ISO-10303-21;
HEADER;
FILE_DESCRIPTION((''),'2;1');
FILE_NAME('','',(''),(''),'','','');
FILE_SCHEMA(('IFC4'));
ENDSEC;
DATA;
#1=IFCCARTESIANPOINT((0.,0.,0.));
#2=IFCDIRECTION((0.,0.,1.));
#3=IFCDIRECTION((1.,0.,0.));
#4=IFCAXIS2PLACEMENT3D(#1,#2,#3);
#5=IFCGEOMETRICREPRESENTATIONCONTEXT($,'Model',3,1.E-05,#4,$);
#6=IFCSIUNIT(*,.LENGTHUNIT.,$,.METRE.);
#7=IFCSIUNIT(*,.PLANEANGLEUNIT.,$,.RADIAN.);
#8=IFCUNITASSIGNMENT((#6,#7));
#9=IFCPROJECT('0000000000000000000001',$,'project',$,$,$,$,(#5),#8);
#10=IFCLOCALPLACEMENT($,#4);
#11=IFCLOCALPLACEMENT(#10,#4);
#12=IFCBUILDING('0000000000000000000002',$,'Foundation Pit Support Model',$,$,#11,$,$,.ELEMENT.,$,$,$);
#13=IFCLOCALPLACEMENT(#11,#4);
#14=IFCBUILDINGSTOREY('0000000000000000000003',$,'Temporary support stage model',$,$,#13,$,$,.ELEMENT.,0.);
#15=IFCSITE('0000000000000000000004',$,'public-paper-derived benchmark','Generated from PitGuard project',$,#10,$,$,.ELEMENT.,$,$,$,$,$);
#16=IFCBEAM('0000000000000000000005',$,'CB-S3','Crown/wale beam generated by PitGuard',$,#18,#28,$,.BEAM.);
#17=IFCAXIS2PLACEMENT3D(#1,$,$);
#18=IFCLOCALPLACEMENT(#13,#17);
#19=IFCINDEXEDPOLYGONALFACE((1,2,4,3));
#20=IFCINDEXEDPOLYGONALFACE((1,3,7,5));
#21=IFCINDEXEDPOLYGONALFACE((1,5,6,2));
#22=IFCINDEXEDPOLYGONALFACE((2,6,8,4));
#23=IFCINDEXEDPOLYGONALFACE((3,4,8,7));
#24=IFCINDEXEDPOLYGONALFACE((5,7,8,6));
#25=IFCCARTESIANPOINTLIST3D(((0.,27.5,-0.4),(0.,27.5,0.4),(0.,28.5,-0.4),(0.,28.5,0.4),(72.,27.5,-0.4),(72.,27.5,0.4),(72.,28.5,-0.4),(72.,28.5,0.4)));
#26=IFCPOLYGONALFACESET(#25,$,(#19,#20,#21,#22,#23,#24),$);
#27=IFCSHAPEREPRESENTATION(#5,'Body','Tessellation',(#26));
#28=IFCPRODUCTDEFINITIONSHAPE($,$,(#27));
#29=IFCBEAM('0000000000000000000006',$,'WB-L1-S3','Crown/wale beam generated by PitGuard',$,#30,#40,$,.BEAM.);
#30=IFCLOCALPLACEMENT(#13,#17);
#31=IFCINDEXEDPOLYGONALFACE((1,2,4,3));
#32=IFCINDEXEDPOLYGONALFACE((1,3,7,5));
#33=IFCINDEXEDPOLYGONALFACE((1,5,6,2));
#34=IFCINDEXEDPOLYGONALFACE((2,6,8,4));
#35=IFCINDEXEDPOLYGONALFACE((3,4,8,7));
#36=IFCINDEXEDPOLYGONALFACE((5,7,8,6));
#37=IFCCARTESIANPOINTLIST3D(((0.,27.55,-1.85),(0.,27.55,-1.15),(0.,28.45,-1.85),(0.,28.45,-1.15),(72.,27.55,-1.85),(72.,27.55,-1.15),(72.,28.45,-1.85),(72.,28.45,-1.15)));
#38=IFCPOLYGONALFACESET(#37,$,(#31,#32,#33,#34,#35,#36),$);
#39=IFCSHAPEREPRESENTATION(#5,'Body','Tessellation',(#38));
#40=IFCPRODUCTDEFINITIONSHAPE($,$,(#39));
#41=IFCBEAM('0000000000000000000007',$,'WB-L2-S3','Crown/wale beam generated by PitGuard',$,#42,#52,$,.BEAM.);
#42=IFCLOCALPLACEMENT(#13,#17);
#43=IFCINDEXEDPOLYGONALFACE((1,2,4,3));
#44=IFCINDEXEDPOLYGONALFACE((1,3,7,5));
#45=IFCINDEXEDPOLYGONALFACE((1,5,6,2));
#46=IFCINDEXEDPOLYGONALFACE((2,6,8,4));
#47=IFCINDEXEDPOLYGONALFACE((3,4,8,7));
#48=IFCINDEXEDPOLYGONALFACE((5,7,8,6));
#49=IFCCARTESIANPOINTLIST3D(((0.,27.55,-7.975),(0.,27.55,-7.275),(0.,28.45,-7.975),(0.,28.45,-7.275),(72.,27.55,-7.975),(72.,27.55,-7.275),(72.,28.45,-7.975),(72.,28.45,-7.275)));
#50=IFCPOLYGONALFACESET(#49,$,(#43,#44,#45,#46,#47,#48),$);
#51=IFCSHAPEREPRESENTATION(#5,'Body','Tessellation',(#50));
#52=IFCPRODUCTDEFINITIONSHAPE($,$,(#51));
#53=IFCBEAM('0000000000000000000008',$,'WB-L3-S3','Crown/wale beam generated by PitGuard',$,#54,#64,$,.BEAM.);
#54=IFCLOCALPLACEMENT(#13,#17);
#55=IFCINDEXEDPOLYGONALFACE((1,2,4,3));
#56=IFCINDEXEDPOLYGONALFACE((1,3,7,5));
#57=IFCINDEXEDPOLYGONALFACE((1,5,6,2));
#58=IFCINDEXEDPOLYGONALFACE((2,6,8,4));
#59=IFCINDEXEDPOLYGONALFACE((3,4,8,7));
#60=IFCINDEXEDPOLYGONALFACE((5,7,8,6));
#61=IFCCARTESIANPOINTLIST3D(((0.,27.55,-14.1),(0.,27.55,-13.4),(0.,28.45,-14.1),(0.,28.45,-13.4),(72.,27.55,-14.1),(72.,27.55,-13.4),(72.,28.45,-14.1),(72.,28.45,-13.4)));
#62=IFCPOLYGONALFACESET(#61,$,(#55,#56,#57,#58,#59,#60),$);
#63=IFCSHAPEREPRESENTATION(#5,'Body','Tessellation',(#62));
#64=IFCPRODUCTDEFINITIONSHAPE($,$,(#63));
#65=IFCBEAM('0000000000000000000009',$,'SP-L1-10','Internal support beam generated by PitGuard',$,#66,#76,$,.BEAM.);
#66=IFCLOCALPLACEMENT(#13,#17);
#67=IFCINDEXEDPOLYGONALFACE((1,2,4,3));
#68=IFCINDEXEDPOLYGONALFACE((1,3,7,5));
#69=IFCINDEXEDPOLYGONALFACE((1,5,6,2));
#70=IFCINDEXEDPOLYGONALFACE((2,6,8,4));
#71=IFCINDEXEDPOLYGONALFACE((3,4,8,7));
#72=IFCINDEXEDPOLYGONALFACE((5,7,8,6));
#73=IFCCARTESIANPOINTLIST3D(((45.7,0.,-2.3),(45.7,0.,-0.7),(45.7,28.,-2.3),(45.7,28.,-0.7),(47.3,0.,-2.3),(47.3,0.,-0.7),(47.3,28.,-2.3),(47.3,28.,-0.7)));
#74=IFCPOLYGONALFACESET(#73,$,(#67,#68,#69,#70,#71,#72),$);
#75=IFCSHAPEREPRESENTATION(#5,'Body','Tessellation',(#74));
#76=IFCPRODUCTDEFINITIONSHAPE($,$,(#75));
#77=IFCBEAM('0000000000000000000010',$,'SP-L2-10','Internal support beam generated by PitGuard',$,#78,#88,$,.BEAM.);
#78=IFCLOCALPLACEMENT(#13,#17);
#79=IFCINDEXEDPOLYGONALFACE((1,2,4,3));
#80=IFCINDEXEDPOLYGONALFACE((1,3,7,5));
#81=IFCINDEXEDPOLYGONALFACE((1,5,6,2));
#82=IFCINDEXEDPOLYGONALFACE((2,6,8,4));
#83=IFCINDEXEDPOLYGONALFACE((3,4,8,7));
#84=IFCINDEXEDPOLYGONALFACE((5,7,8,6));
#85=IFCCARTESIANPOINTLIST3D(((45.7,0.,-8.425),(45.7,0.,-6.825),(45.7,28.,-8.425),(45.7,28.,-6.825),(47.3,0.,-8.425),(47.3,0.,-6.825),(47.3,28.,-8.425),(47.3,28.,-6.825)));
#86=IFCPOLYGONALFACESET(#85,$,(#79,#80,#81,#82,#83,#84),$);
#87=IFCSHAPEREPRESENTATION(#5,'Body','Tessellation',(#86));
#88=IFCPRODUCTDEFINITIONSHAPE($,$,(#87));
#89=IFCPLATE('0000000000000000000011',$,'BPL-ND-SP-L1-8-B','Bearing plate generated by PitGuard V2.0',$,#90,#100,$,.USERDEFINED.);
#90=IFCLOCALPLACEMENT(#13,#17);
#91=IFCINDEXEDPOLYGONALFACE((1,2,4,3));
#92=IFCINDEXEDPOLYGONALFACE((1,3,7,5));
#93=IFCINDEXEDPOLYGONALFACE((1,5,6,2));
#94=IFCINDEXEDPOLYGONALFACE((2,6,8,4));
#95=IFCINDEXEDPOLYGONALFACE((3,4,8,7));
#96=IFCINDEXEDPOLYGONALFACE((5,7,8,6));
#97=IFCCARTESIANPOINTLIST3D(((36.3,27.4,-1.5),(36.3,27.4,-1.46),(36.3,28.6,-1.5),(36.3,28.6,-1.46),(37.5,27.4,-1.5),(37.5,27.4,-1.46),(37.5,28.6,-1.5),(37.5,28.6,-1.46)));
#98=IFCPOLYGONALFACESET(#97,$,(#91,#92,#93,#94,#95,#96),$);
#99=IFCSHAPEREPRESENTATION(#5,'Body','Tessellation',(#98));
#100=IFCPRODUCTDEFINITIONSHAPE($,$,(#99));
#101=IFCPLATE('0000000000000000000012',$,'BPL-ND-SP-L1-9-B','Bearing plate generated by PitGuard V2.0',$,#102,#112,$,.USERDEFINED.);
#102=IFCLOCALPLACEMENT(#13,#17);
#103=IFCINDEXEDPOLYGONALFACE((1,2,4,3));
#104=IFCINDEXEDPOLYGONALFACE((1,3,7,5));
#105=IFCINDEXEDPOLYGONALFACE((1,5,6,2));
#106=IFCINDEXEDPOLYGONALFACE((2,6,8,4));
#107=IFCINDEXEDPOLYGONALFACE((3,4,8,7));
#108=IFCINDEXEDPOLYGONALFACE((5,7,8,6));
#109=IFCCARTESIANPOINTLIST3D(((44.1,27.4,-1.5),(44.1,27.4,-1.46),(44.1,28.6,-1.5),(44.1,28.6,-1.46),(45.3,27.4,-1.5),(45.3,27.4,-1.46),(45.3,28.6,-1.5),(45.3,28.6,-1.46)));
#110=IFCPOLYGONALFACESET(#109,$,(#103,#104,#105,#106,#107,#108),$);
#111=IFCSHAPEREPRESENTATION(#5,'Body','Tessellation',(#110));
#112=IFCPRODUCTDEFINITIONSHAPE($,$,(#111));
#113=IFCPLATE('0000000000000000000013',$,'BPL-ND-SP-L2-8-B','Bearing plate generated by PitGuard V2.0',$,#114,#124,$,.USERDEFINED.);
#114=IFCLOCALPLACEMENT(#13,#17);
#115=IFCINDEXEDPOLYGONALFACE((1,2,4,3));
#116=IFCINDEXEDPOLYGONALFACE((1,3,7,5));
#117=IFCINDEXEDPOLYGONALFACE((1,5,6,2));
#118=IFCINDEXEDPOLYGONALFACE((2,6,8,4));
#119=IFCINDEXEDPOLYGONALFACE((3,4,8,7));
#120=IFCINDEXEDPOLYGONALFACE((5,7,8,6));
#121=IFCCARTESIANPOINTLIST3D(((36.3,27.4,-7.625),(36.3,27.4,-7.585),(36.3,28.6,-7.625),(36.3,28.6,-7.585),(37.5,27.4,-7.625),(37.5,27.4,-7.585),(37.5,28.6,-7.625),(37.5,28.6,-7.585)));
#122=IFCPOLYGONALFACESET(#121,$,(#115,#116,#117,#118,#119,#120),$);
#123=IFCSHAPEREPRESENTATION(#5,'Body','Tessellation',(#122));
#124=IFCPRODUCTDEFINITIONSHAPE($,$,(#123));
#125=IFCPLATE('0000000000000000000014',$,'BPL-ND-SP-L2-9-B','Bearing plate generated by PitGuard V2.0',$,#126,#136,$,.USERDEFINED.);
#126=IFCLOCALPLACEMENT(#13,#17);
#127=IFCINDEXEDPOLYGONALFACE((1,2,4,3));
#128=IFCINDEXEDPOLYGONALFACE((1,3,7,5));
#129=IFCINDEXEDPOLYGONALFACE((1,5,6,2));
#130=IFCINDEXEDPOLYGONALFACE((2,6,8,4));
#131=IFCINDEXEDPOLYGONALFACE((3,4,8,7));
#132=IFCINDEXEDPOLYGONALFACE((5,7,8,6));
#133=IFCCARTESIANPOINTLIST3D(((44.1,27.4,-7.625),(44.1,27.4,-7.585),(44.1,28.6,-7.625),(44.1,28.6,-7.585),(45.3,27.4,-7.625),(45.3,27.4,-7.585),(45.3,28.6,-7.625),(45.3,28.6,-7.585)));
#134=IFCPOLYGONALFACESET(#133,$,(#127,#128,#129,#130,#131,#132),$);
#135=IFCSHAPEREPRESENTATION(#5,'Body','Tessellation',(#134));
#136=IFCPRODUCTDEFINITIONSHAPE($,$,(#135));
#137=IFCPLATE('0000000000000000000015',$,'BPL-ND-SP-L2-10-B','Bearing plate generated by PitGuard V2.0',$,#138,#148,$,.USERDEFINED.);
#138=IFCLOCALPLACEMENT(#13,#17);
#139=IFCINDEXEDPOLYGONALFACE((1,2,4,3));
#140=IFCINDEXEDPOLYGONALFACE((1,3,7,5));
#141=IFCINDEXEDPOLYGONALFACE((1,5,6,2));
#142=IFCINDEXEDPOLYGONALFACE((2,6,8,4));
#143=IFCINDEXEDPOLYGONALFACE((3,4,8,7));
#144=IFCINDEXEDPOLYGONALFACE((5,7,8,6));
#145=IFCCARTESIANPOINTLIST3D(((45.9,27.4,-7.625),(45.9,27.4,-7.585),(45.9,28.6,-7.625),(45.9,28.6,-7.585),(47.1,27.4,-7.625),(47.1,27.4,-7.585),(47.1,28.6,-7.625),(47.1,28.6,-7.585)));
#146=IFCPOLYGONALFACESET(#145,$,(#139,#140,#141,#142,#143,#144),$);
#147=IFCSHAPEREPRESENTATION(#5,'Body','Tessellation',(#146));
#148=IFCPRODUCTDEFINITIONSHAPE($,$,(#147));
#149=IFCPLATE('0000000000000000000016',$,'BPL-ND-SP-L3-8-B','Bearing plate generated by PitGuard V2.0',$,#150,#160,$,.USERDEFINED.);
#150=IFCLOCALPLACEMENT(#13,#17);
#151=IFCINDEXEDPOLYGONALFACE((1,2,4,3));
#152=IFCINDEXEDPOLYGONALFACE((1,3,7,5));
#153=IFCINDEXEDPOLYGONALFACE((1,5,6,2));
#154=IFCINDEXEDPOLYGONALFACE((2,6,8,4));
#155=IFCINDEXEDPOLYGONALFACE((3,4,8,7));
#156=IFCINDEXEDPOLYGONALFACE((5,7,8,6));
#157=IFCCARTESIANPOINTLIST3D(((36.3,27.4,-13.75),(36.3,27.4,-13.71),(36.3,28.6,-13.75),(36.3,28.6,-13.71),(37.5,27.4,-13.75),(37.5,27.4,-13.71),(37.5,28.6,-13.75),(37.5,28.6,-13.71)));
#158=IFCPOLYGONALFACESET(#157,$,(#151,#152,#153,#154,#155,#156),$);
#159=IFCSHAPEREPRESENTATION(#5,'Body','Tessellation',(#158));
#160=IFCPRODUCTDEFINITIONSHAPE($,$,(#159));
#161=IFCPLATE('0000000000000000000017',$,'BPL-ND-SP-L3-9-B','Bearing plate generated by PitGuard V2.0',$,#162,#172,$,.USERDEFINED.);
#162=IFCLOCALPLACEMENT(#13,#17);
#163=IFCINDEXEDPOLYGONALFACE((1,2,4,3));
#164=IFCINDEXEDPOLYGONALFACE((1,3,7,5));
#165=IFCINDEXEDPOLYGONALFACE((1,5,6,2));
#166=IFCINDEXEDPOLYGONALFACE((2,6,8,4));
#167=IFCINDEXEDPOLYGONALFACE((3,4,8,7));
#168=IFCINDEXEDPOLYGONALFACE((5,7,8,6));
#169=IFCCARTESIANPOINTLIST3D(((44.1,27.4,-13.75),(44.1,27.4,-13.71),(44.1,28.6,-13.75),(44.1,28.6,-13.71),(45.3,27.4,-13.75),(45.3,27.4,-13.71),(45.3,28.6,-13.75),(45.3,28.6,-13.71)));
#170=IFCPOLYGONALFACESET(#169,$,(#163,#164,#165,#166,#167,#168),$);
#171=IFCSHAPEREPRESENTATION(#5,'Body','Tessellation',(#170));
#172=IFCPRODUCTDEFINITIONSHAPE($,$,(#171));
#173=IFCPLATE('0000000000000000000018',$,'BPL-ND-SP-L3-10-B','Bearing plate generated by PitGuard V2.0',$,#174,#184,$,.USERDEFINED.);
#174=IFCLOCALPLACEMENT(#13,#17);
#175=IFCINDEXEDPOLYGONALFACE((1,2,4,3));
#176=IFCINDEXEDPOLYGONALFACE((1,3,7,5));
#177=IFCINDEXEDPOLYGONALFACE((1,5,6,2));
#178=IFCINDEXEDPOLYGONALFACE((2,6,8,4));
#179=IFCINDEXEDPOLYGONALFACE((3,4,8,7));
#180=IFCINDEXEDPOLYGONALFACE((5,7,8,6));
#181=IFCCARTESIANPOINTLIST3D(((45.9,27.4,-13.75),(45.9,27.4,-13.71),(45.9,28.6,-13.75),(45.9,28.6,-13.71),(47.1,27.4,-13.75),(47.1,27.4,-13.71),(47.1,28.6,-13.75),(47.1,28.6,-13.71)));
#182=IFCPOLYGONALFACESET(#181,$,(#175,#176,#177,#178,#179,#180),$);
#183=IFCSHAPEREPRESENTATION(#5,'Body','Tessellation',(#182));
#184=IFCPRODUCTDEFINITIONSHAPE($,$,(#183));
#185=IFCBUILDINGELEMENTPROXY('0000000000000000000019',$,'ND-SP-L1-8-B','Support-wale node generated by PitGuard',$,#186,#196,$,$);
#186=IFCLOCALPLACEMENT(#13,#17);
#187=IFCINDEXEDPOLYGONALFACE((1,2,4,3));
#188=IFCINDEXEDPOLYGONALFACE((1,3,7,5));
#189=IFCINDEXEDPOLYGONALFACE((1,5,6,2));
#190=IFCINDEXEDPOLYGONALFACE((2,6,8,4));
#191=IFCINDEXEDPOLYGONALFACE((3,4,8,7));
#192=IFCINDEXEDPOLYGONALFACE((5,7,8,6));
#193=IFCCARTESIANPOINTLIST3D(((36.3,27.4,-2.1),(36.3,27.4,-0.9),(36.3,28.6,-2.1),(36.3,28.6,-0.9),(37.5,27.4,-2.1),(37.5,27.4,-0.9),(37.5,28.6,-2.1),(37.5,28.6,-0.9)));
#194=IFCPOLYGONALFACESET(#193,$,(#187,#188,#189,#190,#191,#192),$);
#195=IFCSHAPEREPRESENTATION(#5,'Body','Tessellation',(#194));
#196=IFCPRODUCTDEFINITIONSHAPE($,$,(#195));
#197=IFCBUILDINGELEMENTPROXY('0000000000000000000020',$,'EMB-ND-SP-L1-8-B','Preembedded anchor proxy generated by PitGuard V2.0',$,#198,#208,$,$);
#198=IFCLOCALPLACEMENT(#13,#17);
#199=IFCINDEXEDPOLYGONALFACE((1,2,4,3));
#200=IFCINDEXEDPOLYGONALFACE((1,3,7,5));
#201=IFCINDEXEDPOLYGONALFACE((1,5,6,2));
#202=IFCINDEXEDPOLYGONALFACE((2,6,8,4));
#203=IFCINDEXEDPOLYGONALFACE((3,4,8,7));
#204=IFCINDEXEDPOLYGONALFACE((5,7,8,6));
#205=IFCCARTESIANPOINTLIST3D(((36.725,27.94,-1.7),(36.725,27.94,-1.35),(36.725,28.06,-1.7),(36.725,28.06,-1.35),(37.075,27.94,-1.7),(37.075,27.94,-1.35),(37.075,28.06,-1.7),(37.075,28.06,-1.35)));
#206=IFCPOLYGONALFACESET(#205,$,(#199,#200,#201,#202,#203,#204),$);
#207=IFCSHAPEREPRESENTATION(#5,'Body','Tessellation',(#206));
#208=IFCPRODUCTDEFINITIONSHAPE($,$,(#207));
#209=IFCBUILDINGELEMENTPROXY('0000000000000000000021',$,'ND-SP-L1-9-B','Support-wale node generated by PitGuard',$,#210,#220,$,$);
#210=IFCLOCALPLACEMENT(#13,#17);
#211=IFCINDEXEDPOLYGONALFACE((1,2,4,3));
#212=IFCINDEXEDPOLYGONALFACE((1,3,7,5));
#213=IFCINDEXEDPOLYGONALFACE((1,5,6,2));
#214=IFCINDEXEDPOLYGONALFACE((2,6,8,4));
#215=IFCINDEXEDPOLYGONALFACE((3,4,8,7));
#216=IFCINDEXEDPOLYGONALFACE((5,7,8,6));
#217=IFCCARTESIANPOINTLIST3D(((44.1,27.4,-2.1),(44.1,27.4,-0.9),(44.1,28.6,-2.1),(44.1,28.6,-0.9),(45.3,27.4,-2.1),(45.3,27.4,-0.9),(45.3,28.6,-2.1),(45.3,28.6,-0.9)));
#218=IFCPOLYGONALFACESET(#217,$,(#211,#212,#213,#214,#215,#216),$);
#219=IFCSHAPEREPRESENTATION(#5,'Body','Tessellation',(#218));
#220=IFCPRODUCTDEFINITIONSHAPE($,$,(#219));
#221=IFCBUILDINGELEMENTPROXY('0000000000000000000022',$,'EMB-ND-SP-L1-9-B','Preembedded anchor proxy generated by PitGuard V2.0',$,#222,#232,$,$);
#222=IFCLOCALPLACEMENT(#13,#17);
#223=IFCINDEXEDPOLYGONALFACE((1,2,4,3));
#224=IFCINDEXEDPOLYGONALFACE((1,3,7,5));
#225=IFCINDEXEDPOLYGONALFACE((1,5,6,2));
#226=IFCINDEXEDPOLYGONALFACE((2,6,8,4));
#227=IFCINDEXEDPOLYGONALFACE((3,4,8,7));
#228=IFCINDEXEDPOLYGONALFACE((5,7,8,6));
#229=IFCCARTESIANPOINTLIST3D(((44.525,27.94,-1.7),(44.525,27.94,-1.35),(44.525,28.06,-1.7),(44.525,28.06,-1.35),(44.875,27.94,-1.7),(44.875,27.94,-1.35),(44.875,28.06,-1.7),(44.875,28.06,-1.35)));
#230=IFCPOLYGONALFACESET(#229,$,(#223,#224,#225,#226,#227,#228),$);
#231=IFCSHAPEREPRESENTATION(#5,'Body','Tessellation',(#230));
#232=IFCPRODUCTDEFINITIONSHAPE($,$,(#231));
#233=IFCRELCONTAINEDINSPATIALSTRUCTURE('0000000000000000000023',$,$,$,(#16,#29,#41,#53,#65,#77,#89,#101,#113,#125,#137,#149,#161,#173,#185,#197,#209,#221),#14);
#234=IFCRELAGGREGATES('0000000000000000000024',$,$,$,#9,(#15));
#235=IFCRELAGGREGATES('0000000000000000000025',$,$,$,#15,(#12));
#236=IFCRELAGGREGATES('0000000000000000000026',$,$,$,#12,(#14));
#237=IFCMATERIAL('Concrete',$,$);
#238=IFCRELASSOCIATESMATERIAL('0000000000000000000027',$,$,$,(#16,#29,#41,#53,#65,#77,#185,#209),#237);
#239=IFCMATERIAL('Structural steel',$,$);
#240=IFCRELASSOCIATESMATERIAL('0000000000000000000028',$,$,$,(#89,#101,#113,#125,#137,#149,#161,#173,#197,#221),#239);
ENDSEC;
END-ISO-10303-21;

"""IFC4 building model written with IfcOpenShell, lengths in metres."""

from ifc_helpers import new_model, si_unit, frame, origin_with_axes, origin_2d, place, context, project, spatial, rectangle, extrude, material, element, save


model = new_model("IFC4")

# Units and contexts
model_context = context("Model", 3, precision=1e-05, world=origin_with_axes())
ifc_project = project(units=[si_unit("LENGTHUNIT", "METRE"), si_unit("PLANEANGLEUNIT", "RADIAN")], contexts=[model_context])

# Site, building, storey
site_placement = place(None, origin_with_axes())
site = spatial("IfcSite", under=ifc_project, at=site_placement, Name="public-paper-derived benchmark", Description="Generated from PitGuard project", CompositionType="ELEMENT")
building_placement = place(site_placement, origin_with_axes())
building = spatial("IfcBuilding", under=site, at=building_placement, Name="Foundation Pit Support Model", CompositionType="ELEMENT")
storey_placement = place(building_placement, origin_with_axes())
storey = spatial("IfcBuildingStorey", under=building, at=storey_placement, Name="Temporary support stage model", CompositionType="ELEMENT", Elevation=0.0)

# Beams
ifc_material_1 = material(Name="Concrete")
beam_placement = place(storey_placement, frame((36.0, 28.0, -0.4), z_axis=(0.0, 0.0, 1.0), x_axis=(-1.0, 0.0, 0.0)))
element("IfcBeam", 1, at=beam_placement, inside=storey, material=ifc_material_1, Name="CB-S3", Description="Crown/wale beam generated by PitGuard", PredefinedType="BEAM", context=model_context, shape_type="SweptSolid", body=[
    extrude(rectangle(XDim=72.0, YDim=1.0, at=origin_2d()), origin_with_axes(), (0.0, 0.0, 1.0), 0.8),
])
for number, where, z_axis, x_axis, name in (
    (2, (36.0, 28.0, -1.85), (0.0, 0.0, 1.0), (-1.0, 0.0, 0.0), "WB-L1-S3"),
    (3, (36.0, 28.0, -7.975), (0.0, 0.0, 1.0), (-1.0, 0.0, 0.0), "WB-L2-S3"),
    (4, (36.0, 28.0, -14.1), (0.0, 0.0, 1.0), (-1.0, 0.0, 0.0), "WB-L3-S3"),
):
    element("IfcBeam", number, at=place(storey_placement, frame(where, z_axis=z_axis, x_axis=x_axis)), inside=storey, material=ifc_material_1, Name=name, Description="Crown/wale beam generated by PitGuard", PredefinedType="BEAM", context=model_context, shape_type="SweptSolid", body=[
        extrude(rectangle(XDim=72.0, YDim=0.9, at=origin_2d()), origin_with_axes(), (0.0, 0.0, 1.0), 0.7),
    ])
for number, where, z_axis, x_axis, name in (
    (5, (46.5, 14.0, -2.3), (0.0, 0.0, 1.0), (0.0, 1.0, 0.0), "SP-L1-10"),
    (6, (46.5, 14.0, -8.425), (0.0, 0.0, 1.0), (0.0, 1.0, 0.0), "SP-L2-10"),
):
    element("IfcBeam", number, at=place(storey_placement, frame(where, z_axis=z_axis, x_axis=x_axis)), inside=storey, material=ifc_material_1, Name=name, Description="Internal support beam generated by PitGuard", PredefinedType="BEAM", context=model_context, shape_type="SweptSolid", body=[
        extrude(rectangle(XDim=28.0, YDim=1.6, at=origin_2d()), origin_with_axes(), (0.0, 0.0, 1.0), 1.6),
    ])

# Plates
ifc_material_2 = material(Name="Structural steel")
for number, where, z_axis, x_axis, name in (
    (7, (36.9, 28.0, -1.5), (0.0, 0.0, 1.0), (1.0, 0.0, 0.0), "BPL-ND-SP-L1-8-B"),
    (8, (44.7, 28.0, -1.5), (0.0, 0.0, 1.0), (1.0, 0.0, 0.0), "BPL-ND-SP-L1-9-B"),
    (9, (36.9, 28.0, -7.625), (0.0, 0.0, 1.0), (1.0, 0.0, 0.0), "BPL-ND-SP-L2-8-B"),
    (10, (44.7, 28.0, -7.625), (0.0, 0.0, 1.0), (1.0, 0.0, 0.0), "BPL-ND-SP-L2-9-B"),
    (11, (46.5, 28.0, -7.625), (0.0, 0.0, 1.0), (1.0, 0.0, 0.0), "BPL-ND-SP-L2-10-B"),
    (12, (36.9, 28.0, -13.75), (0.0, 0.0, 1.0), (1.0, 0.0, 0.0), "BPL-ND-SP-L3-8-B"),
    (13, (44.7, 28.0, -13.75), (0.0, 0.0, 1.0), (1.0, 0.0, 0.0), "BPL-ND-SP-L3-9-B"),
    (14, (46.5, 28.0, -13.75), (0.0, 0.0, 1.0), (1.0, 0.0, 0.0), "BPL-ND-SP-L3-10-B"),
):
    element("IfcPlate", number, at=place(storey_placement, frame(where, z_axis=z_axis, x_axis=x_axis)), inside=storey, material=ifc_material_2, Name=name, Description="Bearing plate generated by PitGuard V2.0", PredefinedType="USERDEFINED", context=model_context, shape_type="SweptSolid", body=[
        extrude(rectangle(XDim=1.2, YDim=1.2, at=origin_2d()), origin_with_axes(), (0.0, 0.0, 1.0), 0.04),
    ])

# Building element proxies
proxy_1_placement = place(storey_placement, frame((36.9, 28.0, -2.1), z_axis=(0.0, 0.0, 1.0), x_axis=(1.0, 0.0, 0.0)))
element("IfcBuildingElementProxy", 15, at=proxy_1_placement, inside=storey, material=ifc_material_1, Name="ND-SP-L1-8-B", Description="Support-wale node generated by PitGuard", context=model_context, shape_type="SweptSolid", body=[
    extrude(rectangle(XDim=1.2, YDim=1.2, at=origin_2d()), origin_with_axes(), (0.0, 0.0, 1.0), 1.2),
])
proxy_2_placement = place(storey_placement, frame((36.9, 28.0, -1.7), z_axis=(0.0, 0.0, 1.0), x_axis=(1.0, 0.0, 0.0)))
element("IfcBuildingElementProxy", 16, at=proxy_2_placement, inside=storey, material=ifc_material_2, Name="EMB-ND-SP-L1-8-B", Description="Preembedded anchor proxy generated by PitGuard V2.0", context=model_context, shape_type="SweptSolid", body=[
    extrude(rectangle(XDim=0.35, YDim=0.12, at=origin_2d()), origin_with_axes(), (0.0, 0.0, 1.0), 0.35),
])
proxy_3_placement = place(storey_placement, frame((44.7, 28.0, -2.1), z_axis=(0.0, 0.0, 1.0), x_axis=(1.0, 0.0, 0.0)))
element("IfcBuildingElementProxy", 17, at=proxy_3_placement, inside=storey, material=ifc_material_1, Name="ND-SP-L1-9-B", Description="Support-wale node generated by PitGuard", context=model_context, shape_type="SweptSolid", body=[
    extrude(rectangle(XDim=1.2, YDim=1.2, at=origin_2d()), origin_with_axes(), (0.0, 0.0, 1.0), 1.2),
])
proxy_4_placement = place(storey_placement, frame((44.7, 28.0, -1.7), z_axis=(0.0, 0.0, 1.0), x_axis=(1.0, 0.0, 0.0)))
element("IfcBuildingElementProxy", 18, at=proxy_4_placement, inside=storey, material=ifc_material_2, Name="EMB-ND-SP-L1-9-B", Description="Preembedded anchor proxy generated by PitGuard V2.0", context=model_context, shape_type="SweptSolid", body=[
    extrude(rectangle(XDim=0.35, YDim=0.12, at=origin_2d()), origin_with_axes(), (0.0, 0.0, 1.0), 0.35),
])

save(model, "model.ifc")
